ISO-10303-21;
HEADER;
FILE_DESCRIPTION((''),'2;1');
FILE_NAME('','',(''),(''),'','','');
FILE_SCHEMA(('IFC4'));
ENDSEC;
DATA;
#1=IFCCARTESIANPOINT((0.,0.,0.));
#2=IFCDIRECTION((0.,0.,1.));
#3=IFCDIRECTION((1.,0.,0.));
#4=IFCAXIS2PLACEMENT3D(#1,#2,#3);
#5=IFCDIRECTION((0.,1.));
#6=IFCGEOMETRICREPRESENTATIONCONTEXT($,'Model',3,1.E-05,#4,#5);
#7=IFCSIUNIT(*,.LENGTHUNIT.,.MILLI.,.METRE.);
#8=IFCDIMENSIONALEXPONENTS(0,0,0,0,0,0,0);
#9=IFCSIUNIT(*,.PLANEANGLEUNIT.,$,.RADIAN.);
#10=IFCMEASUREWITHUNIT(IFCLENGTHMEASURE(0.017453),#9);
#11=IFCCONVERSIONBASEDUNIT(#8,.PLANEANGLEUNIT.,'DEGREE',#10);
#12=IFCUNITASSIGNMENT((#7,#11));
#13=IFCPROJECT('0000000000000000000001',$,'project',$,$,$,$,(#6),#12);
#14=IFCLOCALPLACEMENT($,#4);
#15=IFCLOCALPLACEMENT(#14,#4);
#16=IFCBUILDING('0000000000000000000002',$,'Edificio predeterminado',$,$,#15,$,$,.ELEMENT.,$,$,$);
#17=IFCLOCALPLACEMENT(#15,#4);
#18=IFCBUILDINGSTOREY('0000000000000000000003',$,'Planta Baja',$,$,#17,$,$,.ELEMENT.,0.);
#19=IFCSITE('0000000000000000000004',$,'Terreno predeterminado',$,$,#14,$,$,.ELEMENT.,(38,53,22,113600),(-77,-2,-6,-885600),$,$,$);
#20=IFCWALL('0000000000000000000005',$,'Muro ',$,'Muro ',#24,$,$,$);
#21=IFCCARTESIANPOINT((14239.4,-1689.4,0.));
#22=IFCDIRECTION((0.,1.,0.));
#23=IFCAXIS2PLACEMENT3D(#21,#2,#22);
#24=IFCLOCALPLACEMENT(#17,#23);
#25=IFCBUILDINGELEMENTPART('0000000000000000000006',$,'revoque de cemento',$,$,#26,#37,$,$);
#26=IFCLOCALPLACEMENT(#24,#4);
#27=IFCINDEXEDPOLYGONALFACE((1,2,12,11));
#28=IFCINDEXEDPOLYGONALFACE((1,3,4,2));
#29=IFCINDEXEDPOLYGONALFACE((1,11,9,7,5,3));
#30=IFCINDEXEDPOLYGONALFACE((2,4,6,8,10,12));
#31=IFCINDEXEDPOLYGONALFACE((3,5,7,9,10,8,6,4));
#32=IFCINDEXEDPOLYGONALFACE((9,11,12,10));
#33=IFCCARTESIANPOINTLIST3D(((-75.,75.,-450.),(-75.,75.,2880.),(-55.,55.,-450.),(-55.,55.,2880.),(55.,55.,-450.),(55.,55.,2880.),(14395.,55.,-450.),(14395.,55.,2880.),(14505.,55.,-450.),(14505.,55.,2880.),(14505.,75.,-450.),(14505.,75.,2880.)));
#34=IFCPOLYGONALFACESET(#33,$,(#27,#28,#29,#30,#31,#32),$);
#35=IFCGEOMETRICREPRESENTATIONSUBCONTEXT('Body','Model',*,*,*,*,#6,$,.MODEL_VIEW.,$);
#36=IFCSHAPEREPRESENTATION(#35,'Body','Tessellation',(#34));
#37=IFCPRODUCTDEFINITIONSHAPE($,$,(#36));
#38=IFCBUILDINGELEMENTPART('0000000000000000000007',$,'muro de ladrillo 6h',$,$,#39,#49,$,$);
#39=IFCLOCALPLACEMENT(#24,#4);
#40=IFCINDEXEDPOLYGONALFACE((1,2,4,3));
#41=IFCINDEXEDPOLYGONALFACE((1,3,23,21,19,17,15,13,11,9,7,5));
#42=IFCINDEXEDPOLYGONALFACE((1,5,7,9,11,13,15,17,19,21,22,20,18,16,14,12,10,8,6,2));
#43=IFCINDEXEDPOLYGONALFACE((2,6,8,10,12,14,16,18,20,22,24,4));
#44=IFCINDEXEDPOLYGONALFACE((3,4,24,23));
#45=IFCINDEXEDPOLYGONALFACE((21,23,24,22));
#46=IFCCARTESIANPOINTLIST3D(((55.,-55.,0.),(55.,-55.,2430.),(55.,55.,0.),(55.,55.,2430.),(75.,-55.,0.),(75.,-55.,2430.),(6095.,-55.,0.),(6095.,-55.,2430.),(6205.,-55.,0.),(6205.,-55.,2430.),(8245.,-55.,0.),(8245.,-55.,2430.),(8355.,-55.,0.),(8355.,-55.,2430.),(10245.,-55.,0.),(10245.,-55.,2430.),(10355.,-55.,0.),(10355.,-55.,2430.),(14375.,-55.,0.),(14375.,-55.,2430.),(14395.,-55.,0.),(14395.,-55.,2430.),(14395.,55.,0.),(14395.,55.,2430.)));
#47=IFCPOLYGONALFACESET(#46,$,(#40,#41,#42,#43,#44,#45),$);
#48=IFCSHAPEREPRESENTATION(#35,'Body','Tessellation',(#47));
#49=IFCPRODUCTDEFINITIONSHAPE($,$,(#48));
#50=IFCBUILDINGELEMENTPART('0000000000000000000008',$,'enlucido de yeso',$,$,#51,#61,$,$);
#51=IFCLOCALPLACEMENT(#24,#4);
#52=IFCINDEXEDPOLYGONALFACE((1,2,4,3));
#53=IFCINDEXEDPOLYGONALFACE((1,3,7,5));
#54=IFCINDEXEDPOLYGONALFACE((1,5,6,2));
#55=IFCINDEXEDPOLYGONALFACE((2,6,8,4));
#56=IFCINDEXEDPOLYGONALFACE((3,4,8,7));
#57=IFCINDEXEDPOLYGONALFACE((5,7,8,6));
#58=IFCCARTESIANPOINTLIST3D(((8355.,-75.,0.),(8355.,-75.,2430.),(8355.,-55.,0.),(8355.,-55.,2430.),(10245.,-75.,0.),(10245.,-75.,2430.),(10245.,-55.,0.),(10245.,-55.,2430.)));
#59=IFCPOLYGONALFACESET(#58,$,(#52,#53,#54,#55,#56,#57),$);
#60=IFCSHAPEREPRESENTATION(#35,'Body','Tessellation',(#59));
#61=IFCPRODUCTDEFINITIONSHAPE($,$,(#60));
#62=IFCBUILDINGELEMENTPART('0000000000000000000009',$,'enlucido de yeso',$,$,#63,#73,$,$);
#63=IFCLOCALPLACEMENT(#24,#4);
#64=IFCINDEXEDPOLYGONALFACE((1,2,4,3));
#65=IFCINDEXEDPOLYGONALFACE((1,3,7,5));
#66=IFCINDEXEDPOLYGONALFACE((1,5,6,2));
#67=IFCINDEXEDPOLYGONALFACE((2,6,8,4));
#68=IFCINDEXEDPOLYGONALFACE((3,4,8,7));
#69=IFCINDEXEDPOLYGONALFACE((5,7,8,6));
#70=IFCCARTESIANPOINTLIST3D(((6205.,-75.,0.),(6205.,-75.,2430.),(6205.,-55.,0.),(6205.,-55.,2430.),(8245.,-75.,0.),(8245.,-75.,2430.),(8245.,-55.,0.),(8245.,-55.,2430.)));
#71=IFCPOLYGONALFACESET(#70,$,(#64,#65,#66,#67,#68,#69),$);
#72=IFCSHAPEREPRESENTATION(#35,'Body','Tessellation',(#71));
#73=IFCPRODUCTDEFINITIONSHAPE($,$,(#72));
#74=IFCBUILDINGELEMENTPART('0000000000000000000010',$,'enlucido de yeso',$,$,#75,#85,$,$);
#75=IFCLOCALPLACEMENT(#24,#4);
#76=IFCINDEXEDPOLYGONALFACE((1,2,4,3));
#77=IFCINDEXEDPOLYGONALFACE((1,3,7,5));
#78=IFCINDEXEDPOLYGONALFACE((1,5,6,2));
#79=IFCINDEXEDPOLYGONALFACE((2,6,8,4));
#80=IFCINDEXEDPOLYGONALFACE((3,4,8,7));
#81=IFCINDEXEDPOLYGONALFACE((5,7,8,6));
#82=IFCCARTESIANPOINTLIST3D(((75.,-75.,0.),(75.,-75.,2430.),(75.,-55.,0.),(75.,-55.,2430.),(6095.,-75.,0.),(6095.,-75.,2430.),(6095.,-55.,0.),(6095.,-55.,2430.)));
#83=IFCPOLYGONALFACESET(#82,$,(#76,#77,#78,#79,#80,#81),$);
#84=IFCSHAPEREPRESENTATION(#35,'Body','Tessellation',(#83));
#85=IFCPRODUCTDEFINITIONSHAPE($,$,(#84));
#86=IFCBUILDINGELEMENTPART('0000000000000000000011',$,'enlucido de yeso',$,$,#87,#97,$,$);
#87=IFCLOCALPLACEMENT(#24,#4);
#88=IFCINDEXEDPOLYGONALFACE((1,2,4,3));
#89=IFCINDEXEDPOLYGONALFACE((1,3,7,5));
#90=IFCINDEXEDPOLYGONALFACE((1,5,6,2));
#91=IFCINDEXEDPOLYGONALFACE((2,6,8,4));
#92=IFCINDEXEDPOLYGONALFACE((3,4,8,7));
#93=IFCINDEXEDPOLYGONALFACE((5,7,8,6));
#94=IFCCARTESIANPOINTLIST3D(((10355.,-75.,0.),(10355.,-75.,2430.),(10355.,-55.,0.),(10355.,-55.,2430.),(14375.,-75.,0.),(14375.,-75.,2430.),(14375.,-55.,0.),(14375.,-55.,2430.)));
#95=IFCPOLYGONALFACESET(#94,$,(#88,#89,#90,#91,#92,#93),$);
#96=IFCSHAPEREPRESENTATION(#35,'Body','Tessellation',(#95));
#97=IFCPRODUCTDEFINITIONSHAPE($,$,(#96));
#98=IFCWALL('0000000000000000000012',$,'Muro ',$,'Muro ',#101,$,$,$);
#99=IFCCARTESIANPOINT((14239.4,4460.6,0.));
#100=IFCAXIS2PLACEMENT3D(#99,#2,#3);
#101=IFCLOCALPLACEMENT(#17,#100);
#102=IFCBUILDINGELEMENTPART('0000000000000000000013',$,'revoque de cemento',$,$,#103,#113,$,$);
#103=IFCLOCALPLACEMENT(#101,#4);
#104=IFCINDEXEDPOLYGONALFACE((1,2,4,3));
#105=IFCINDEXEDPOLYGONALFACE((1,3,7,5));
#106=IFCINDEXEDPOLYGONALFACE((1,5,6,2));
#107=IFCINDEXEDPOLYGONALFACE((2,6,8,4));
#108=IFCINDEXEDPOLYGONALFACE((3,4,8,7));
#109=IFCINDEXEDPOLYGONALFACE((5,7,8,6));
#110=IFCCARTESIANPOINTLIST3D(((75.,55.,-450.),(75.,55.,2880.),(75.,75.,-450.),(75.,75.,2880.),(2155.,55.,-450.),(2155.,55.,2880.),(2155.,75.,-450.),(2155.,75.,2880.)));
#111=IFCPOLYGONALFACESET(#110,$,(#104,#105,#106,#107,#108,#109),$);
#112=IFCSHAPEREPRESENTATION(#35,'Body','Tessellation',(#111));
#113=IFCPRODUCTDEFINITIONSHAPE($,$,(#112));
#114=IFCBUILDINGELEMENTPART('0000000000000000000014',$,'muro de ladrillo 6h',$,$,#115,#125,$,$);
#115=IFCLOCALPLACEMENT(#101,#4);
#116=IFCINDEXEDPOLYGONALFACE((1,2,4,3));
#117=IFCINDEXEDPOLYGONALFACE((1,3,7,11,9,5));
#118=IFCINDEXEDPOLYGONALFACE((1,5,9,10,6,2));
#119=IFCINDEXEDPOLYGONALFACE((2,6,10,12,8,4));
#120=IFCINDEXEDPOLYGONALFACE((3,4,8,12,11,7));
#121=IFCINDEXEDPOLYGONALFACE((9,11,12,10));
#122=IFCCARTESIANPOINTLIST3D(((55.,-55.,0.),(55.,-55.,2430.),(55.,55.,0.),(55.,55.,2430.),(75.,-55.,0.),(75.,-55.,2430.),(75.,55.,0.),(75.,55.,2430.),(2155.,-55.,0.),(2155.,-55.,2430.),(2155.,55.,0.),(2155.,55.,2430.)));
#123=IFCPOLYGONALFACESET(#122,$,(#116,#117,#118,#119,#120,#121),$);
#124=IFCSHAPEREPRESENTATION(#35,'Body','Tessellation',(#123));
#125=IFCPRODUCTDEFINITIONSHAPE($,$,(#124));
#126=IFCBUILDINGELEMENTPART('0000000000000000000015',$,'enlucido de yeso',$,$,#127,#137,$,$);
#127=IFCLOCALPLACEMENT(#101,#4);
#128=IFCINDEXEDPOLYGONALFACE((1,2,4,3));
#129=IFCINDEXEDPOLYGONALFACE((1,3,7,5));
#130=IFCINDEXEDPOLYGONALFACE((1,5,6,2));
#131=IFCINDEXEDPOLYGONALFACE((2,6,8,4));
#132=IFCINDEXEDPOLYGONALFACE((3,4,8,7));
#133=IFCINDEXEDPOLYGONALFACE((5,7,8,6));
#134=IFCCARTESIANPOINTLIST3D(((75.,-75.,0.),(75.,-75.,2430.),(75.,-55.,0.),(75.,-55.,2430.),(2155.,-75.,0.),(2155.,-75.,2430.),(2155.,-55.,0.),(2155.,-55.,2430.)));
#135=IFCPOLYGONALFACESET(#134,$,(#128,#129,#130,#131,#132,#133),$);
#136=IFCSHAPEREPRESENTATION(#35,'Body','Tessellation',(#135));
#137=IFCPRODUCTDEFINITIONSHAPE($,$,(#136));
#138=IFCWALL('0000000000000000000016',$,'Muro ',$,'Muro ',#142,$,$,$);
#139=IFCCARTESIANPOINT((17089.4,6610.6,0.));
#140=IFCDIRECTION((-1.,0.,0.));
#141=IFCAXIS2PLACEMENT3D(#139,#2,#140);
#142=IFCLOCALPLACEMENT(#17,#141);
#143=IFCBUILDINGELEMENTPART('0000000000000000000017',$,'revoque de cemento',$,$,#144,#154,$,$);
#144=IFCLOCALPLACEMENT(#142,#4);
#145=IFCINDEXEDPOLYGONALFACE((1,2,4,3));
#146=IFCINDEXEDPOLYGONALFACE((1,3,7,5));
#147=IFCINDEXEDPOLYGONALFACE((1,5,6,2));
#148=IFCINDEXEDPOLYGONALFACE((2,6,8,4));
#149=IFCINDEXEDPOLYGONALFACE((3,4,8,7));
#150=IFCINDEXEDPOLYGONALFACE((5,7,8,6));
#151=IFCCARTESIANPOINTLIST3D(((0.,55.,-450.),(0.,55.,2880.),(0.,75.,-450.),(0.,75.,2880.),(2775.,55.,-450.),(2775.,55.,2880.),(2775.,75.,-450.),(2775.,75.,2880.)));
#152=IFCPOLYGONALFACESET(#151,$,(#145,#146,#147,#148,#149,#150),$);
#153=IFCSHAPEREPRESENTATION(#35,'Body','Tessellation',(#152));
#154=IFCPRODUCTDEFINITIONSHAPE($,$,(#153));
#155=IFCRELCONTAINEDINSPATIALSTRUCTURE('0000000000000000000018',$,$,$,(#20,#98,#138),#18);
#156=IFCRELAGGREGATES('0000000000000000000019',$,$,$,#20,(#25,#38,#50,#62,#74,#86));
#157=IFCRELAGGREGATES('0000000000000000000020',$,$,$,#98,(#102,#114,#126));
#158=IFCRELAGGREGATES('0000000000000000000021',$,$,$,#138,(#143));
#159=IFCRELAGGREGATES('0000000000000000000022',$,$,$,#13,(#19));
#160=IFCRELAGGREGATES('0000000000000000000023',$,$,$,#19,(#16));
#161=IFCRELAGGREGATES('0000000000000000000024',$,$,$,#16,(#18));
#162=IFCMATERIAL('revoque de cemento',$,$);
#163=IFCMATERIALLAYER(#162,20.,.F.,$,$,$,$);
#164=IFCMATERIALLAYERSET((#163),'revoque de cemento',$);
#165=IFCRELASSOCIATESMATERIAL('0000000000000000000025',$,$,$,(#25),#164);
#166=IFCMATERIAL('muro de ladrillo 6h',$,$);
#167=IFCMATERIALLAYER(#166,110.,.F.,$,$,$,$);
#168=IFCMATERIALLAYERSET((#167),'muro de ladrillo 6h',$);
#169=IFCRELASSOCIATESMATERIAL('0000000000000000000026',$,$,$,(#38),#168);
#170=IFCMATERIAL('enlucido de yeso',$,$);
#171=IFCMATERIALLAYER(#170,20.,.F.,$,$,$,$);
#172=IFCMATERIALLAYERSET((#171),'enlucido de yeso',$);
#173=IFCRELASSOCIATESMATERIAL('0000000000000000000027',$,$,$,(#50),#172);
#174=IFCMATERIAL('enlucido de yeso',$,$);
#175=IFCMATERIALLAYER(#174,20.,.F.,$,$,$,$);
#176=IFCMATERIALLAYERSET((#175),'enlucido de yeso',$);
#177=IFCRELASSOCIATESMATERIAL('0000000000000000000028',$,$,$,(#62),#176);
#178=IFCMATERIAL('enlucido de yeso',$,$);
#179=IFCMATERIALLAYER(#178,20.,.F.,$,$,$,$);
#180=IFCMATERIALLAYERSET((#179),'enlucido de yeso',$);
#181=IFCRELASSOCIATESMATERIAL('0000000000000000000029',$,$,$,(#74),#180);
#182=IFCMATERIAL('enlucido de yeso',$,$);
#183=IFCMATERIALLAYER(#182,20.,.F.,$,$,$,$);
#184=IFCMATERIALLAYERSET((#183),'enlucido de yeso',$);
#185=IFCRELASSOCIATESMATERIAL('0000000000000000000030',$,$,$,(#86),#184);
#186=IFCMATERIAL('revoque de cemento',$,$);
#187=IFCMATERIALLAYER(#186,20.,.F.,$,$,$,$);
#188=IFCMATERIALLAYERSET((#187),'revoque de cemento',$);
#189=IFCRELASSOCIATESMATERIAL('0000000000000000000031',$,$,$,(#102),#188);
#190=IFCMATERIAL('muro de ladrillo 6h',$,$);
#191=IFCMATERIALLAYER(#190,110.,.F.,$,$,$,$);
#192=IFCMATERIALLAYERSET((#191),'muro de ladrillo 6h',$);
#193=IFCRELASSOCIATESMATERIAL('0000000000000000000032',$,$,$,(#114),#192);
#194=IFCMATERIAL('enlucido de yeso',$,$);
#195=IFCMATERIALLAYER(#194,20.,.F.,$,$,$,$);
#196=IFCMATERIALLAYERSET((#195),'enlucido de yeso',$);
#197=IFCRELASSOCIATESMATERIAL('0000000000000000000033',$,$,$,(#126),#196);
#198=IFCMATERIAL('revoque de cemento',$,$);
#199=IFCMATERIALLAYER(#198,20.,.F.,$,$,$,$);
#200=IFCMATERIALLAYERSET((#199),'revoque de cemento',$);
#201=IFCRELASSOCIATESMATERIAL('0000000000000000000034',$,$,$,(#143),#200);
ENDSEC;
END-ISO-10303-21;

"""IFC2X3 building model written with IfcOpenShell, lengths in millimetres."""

from ifc_helpers import new_model, entity, si_unit, converted_unit, direction, frame, origin_with_axes, place, context, subcontext, project, spatial, polyline, outline, extrude, material, layer, layer_set, layer_usage, element, aggregate, save


model = new_model("IFC2X3")

# Units and contexts
model_context = context("Model", 3, precision=1e-05, world=origin_with_axes(), true_north=direction((0.0, 1.0)))
body_context = subcontext(model_context, "Body", "Model", "MODEL_VIEW")
ifc_project = project(units=[si_unit("LENGTHUNIT", "METRE", prefix="MILLI"), converted_unit("PLANEANGLEUNIT", "DEGREE", entity("IfcLengthMeasure", 0.017453), si_unit("PLANEANGLEUNIT", "RADIAN"), dimensions=[0, 0, 0, 0, 0, 0, 0])], contexts=[model_context])

# Site, building, storey
site_placement = place(None, origin_with_axes())
site = spatial("IfcSite", under=ifc_project, at=site_placement, Name="Terreno predeterminado", CompositionType="ELEMENT", RefLatitude=(38, 53, 22, 113600), RefLongitude=(-77, -2, -6, -885600))
building_placement = place(site_placement, origin_with_axes())
building = spatial("IfcBuilding", under=site, at=building_placement, Name="Edificio predeterminado", CompositionType="ELEMENT")
storey_placement = place(building_placement, origin_with_axes())
storey = spatial("IfcBuildingStorey", under=building, at=storey_placement, Name="Planta Baja", CompositionType="ELEMENT", Elevation=0.0)

# Walls, building element parts
wall_1_placement = place(storey_placement, frame((14239.4, -1689.4, 0.0), z_axis=(0.0, 0.0, 1.0), x_axis=(0.0, 1.0, 0.0)))
wall_1 = element("IfcWall", 1, at=wall_1_placement, inside=storey, Name="Muro ", ObjectType="Muro ")
ifc_material_1 = material(Name="revoque de cemento")
ifc_layer_1 = layer(ifc_material_1, 20.0, ventilated=False)
ifc_layer_set_1 = layer_set([ifc_layer_1], Name="revoque de cemento")
ifc_layer_usage_1 = layer_usage(ifc_layer_set_1, "AXIS2", "NEGATIVE", -75.0)
building_element_part_1_placement = place(wall_1_placement, origin_with_axes())
building_element_part_1 = element("IfcBuildingElementPart", 2, at=building_element_part_1_placement, material=ifc_layer_usage_1, Name="revoque de cemento", context=body_context, shape_type="SweptSolid", body=[
    extrude(outline(polyline([(14505.0, 75.0), (14505.0, 55.0), (14395.0, 55.0), (55.0, 55.0), (-55.0, 55.0), (-75.0, 75.0), (14505.0, 75.0)])), frame((0.0, 0.0, -450.0), z_axis=(0.0, 0.0, 1.0), x_axis=(1.0, 0.0, 0.0)), (0.0, 0.0, 1.0), 3330.0),
])
ifc_material_2 = material(Name="muro de ladrillo 6h")
ifc_layer_2 = layer(ifc_material_2, 110.0, ventilated=False)
ifc_layer_set_2 = layer_set([ifc_layer_2], Name="muro de ladrillo 6h")
ifc_layer_usage_2 = layer_usage(ifc_layer_set_2, "AXIS2", "NEGATIVE", -55.0)
building_element_part_2_placement = place(wall_1_placement, origin_with_axes())
building_element_part_2 = element("IfcBuildingElementPart", 3, at=building_element_part_2_placement, material=ifc_layer_usage_2, Name="muro de ladrillo 6h", context=body_context, shape_type="SweptSolid", body=[
    extrude(outline(polyline([(14395.0, 55.0), (14395.0, -55.0), (14375.0, -55.0), (10355.0, -55.0), (10245.0, -55.0), (8355.0, -55.0), (8245.0, -55.0), (6205.0, -55.0), (6095.0, -55.0), (75.0, -55.0), (55.0, -55.0), (55.0, 55.0), (14395.0, 55.0)])), origin_with_axes(), (0.0, 0.0, 1.0), 2430.0),
])
ifc_material_3 = material(Name="enlucido de yeso")
ifc_layer_3 = layer(ifc_material_3, 20.0, ventilated=False)
ifc_layer_set_3 = layer_set([ifc_layer_3], Name="enlucido de yeso")
ifc_layer_usage_3 = layer_usage(ifc_layer_set_3, "AXIS2", "NEGATIVE", 55.0)
building_element_part_3_placement = place(wall_1_placement, origin_with_axes())
building_element_part_3 = element("IfcBuildingElementPart", 4, at=building_element_part_3_placement, material=ifc_layer_usage_3, Name="enlucido de yeso", context=body_context, shape_type="SweptSolid", body=[
    extrude(outline(polyline([(8355.0, -55.0), (10245.0, -55.0), (10245.0, -75.0), (8355.0, -75.0), (8355.0, -55.0)])), origin_with_axes(), (0.0, 0.0, 1.0), 2430.0),
])
ifc_material_4 = material(Name="enlucido de yeso")
ifc_layer_4 = layer(ifc_material_4, 20.0, ventilated=False)
ifc_layer_set_4 = layer_set([ifc_layer_4], Name="enlucido de yeso")
ifc_layer_usage_4 = layer_usage(ifc_layer_set_4, "AXIS2", "NEGATIVE", 55.0)
building_element_part_4_placement = place(wall_1_placement, origin_with_axes())
building_element_part_4 = element("IfcBuildingElementPart", 5, at=building_element_part_4_placement, material=ifc_layer_usage_4, Name="enlucido de yeso", context=body_context, shape_type="SweptSolid", body=[
    extrude(outline(polyline([(8245.0, -55.0), (8245.0, -75.0), (6205.0, -75.0), (6205.0, -55.0), (8245.0, -55.0)])), origin_with_axes(), (0.0, 0.0, 1.0), 2430.0),
])
ifc_material_5 = material(Name="enlucido de yeso")
ifc_layer_5 = layer(ifc_material_5, 20.0, ventilated=False)
ifc_layer_set_5 = layer_set([ifc_layer_5], Name="enlucido de yeso")
ifc_layer_usage_5 = layer_usage(ifc_layer_set_5, "AXIS2", "NEGATIVE", 55.0)
building_element_part_5_placement = place(wall_1_placement, origin_with_axes())
building_element_part_5 = element("IfcBuildingElementPart", 6, at=building_element_part_5_placement, material=ifc_layer_usage_5, Name="enlucido de yeso", context=body_context, shape_type="SweptSolid", body=[
    extrude(outline(polyline([(6095.0, -55.0), (6095.0, -75.0), (75.0, -75.0), (75.0, -55.0), (6095.0, -55.0)])), origin_with_axes(), (0.0, 0.0, 1.0), 2430.0),
])
ifc_material_6 = material(Name="enlucido de yeso")
ifc_layer_6 = layer(ifc_material_6, 20.0, ventilated=False)
ifc_layer_set_6 = layer_set([ifc_layer_6], Name="enlucido de yeso")
ifc_layer_usage_6 = layer_usage(ifc_layer_set_6, "AXIS2", "NEGATIVE", 55.0)
building_element_part_6_placement = place(wall_1_placement, origin_with_axes())
building_element_part_6 = element("IfcBuildingElementPart", 7, at=building_element_part_6_placement, material=ifc_layer_usage_6, Name="enlucido de yeso", context=body_context, shape_type="SweptSolid", body=[
    extrude(outline(polyline([(14375.0, -55.0), (14375.0, -75.0), (10355.0, -75.0), (10355.0, -55.0), (14375.0, -55.0)])), origin_with_axes(), (0.0, 0.0, 1.0), 2430.0),
])
aggregate(wall_1, [building_element_part_1, building_element_part_2, building_element_part_3, building_element_part_4, building_element_part_5, building_element_part_6])
wall_2_placement = place(storey_placement, frame((14239.4, 4460.6, 0.0), z_axis=(0.0, 0.0, 1.0), x_axis=(1.0, 0.0, 0.0)))
wall_2 = element("IfcWall", 8, at=wall_2_placement, inside=storey, Name="Muro ", ObjectType="Muro ")
ifc_material_7 = material(Name="revoque de cemento")
ifc_layer_7 = layer(ifc_material_7, 20.0, ventilated=False)
ifc_layer_set_7 = layer_set([ifc_layer_7], Name="revoque de cemento")
ifc_layer_usage_7 = layer_usage(ifc_layer_set_7, "AXIS2", "NEGATIVE", -75.0)
building_element_part_7_placement = place(wall_2_placement, origin_with_axes())
building_element_part_7 = element("IfcBuildingElementPart", 9, at=building_element_part_7_placement, material=ifc_layer_usage_7, Name="revoque de cemento", context=body_context, shape_type="SweptSolid", body=[
    extrude(outline(polyline([(2155.0, 75.0), (2155.0, 55.0), (75.0, 55.0), (75.0, 75.0), (2155.0, 75.0)])), frame((0.0, 0.0, -450.0), z_axis=(0.0, 0.0, 1.0), x_axis=(1.0, 0.0, 0.0)), (0.0, 0.0, 1.0), 3330.0),
])
ifc_material_8 = material(Name="muro de ladrillo 6h")
ifc_layer_8 = layer(ifc_material_8, 110.0, ventilated=False)
ifc_layer_set_8 = layer_set([ifc_layer_8], Name="muro de ladrillo 6h")
ifc_layer_usage_8 = layer_usage(ifc_layer_set_8, "AXIS2", "NEGATIVE", -55.0)
building_element_part_8_placement = place(wall_2_placement, origin_with_axes())
building_element_part_8 = element("IfcBuildingElementPart", 10, at=building_element_part_8_placement, material=ifc_layer_usage_8, Name="muro de ladrillo 6h", context=body_context, shape_type="SweptSolid", body=[
    extrude(outline(polyline([(2155.0, 55.0), (2155.0, -55.0), (75.0, -55.0), (55.0, -55.0), (55.0, 55.0), (75.0, 55.0), (2155.0, 55.0)])), origin_with_axes(), (0.0, 0.0, 1.0), 2430.0),
])
ifc_material_9 = material(Name="enlucido de yeso")
ifc_layer_9 = layer(ifc_material_9, 20.0, ventilated=False)
ifc_layer_set_9 = layer_set([ifc_layer_9], Name="enlucido de yeso")
ifc_layer_usage_9 = layer_usage(ifc_layer_set_9, "AXIS2", "NEGATIVE", 55.0)
building_element_part_9_placement = place(wall_2_placement, origin_with_axes())
building_element_part_9 = element("IfcBuildingElementPart", 11, at=building_element_part_9_placement, material=ifc_layer_usage_9, Name="enlucido de yeso", context=body_context, shape_type="SweptSolid", body=[
    extrude(outline(polyline([(2155.0, -55.0), (2155.0, -75.0), (75.0, -75.0), (75.0, -55.0), (2155.0, -55.0)])), origin_with_axes(), (0.0, 0.0, 1.0), 2430.0),
])
aggregate(wall_2, [building_element_part_7, building_element_part_8, building_element_part_9])

# Wall, building element part
wall_3_placement = place(storey_placement, frame((17089.4, 6610.6, 0.0), z_axis=(0.0, 0.0, 1.0), x_axis=(-1.0, 0.0, 0.0)))
wall_3 = element("IfcWall", 12, at=wall_3_placement, inside=storey, Name="Muro ", ObjectType="Muro ")
ifc_material_10 = material(Name="revoque de cemento")
ifc_layer_10 = layer(ifc_material_10, 20.0, ventilated=False)
ifc_layer_set_10 = layer_set([ifc_layer_10], Name="revoque de cemento")
ifc_layer_usage_10 = layer_usage(ifc_layer_set_10, "AXIS2", "NEGATIVE", -75.0)
building_element_part_10_placement = place(wall_3_placement, origin_with_axes())
building_element_part_10 = element("IfcBuildingElementPart", 13, at=building_element_part_10_placement, material=ifc_layer_usage_10, Name="revoque de cemento", context=body_context, shape_type="SweptSolid", body=[
    extrude(outline(polyline([(0.0, 75.0), (2775.0, 75.0), (2775.0, 55.0), (0.0, 55.0), (0.0, 75.0)])), frame((0.0, 0.0, -450.0), z_axis=(0.0, 0.0, 1.0), x_axis=(1.0, 0.0, 0.0)), (0.0, 0.0, 1.0), 3330.0),
])
aggregate(wall_3, [building_element_part_10])

save(model, "model.ifc")
